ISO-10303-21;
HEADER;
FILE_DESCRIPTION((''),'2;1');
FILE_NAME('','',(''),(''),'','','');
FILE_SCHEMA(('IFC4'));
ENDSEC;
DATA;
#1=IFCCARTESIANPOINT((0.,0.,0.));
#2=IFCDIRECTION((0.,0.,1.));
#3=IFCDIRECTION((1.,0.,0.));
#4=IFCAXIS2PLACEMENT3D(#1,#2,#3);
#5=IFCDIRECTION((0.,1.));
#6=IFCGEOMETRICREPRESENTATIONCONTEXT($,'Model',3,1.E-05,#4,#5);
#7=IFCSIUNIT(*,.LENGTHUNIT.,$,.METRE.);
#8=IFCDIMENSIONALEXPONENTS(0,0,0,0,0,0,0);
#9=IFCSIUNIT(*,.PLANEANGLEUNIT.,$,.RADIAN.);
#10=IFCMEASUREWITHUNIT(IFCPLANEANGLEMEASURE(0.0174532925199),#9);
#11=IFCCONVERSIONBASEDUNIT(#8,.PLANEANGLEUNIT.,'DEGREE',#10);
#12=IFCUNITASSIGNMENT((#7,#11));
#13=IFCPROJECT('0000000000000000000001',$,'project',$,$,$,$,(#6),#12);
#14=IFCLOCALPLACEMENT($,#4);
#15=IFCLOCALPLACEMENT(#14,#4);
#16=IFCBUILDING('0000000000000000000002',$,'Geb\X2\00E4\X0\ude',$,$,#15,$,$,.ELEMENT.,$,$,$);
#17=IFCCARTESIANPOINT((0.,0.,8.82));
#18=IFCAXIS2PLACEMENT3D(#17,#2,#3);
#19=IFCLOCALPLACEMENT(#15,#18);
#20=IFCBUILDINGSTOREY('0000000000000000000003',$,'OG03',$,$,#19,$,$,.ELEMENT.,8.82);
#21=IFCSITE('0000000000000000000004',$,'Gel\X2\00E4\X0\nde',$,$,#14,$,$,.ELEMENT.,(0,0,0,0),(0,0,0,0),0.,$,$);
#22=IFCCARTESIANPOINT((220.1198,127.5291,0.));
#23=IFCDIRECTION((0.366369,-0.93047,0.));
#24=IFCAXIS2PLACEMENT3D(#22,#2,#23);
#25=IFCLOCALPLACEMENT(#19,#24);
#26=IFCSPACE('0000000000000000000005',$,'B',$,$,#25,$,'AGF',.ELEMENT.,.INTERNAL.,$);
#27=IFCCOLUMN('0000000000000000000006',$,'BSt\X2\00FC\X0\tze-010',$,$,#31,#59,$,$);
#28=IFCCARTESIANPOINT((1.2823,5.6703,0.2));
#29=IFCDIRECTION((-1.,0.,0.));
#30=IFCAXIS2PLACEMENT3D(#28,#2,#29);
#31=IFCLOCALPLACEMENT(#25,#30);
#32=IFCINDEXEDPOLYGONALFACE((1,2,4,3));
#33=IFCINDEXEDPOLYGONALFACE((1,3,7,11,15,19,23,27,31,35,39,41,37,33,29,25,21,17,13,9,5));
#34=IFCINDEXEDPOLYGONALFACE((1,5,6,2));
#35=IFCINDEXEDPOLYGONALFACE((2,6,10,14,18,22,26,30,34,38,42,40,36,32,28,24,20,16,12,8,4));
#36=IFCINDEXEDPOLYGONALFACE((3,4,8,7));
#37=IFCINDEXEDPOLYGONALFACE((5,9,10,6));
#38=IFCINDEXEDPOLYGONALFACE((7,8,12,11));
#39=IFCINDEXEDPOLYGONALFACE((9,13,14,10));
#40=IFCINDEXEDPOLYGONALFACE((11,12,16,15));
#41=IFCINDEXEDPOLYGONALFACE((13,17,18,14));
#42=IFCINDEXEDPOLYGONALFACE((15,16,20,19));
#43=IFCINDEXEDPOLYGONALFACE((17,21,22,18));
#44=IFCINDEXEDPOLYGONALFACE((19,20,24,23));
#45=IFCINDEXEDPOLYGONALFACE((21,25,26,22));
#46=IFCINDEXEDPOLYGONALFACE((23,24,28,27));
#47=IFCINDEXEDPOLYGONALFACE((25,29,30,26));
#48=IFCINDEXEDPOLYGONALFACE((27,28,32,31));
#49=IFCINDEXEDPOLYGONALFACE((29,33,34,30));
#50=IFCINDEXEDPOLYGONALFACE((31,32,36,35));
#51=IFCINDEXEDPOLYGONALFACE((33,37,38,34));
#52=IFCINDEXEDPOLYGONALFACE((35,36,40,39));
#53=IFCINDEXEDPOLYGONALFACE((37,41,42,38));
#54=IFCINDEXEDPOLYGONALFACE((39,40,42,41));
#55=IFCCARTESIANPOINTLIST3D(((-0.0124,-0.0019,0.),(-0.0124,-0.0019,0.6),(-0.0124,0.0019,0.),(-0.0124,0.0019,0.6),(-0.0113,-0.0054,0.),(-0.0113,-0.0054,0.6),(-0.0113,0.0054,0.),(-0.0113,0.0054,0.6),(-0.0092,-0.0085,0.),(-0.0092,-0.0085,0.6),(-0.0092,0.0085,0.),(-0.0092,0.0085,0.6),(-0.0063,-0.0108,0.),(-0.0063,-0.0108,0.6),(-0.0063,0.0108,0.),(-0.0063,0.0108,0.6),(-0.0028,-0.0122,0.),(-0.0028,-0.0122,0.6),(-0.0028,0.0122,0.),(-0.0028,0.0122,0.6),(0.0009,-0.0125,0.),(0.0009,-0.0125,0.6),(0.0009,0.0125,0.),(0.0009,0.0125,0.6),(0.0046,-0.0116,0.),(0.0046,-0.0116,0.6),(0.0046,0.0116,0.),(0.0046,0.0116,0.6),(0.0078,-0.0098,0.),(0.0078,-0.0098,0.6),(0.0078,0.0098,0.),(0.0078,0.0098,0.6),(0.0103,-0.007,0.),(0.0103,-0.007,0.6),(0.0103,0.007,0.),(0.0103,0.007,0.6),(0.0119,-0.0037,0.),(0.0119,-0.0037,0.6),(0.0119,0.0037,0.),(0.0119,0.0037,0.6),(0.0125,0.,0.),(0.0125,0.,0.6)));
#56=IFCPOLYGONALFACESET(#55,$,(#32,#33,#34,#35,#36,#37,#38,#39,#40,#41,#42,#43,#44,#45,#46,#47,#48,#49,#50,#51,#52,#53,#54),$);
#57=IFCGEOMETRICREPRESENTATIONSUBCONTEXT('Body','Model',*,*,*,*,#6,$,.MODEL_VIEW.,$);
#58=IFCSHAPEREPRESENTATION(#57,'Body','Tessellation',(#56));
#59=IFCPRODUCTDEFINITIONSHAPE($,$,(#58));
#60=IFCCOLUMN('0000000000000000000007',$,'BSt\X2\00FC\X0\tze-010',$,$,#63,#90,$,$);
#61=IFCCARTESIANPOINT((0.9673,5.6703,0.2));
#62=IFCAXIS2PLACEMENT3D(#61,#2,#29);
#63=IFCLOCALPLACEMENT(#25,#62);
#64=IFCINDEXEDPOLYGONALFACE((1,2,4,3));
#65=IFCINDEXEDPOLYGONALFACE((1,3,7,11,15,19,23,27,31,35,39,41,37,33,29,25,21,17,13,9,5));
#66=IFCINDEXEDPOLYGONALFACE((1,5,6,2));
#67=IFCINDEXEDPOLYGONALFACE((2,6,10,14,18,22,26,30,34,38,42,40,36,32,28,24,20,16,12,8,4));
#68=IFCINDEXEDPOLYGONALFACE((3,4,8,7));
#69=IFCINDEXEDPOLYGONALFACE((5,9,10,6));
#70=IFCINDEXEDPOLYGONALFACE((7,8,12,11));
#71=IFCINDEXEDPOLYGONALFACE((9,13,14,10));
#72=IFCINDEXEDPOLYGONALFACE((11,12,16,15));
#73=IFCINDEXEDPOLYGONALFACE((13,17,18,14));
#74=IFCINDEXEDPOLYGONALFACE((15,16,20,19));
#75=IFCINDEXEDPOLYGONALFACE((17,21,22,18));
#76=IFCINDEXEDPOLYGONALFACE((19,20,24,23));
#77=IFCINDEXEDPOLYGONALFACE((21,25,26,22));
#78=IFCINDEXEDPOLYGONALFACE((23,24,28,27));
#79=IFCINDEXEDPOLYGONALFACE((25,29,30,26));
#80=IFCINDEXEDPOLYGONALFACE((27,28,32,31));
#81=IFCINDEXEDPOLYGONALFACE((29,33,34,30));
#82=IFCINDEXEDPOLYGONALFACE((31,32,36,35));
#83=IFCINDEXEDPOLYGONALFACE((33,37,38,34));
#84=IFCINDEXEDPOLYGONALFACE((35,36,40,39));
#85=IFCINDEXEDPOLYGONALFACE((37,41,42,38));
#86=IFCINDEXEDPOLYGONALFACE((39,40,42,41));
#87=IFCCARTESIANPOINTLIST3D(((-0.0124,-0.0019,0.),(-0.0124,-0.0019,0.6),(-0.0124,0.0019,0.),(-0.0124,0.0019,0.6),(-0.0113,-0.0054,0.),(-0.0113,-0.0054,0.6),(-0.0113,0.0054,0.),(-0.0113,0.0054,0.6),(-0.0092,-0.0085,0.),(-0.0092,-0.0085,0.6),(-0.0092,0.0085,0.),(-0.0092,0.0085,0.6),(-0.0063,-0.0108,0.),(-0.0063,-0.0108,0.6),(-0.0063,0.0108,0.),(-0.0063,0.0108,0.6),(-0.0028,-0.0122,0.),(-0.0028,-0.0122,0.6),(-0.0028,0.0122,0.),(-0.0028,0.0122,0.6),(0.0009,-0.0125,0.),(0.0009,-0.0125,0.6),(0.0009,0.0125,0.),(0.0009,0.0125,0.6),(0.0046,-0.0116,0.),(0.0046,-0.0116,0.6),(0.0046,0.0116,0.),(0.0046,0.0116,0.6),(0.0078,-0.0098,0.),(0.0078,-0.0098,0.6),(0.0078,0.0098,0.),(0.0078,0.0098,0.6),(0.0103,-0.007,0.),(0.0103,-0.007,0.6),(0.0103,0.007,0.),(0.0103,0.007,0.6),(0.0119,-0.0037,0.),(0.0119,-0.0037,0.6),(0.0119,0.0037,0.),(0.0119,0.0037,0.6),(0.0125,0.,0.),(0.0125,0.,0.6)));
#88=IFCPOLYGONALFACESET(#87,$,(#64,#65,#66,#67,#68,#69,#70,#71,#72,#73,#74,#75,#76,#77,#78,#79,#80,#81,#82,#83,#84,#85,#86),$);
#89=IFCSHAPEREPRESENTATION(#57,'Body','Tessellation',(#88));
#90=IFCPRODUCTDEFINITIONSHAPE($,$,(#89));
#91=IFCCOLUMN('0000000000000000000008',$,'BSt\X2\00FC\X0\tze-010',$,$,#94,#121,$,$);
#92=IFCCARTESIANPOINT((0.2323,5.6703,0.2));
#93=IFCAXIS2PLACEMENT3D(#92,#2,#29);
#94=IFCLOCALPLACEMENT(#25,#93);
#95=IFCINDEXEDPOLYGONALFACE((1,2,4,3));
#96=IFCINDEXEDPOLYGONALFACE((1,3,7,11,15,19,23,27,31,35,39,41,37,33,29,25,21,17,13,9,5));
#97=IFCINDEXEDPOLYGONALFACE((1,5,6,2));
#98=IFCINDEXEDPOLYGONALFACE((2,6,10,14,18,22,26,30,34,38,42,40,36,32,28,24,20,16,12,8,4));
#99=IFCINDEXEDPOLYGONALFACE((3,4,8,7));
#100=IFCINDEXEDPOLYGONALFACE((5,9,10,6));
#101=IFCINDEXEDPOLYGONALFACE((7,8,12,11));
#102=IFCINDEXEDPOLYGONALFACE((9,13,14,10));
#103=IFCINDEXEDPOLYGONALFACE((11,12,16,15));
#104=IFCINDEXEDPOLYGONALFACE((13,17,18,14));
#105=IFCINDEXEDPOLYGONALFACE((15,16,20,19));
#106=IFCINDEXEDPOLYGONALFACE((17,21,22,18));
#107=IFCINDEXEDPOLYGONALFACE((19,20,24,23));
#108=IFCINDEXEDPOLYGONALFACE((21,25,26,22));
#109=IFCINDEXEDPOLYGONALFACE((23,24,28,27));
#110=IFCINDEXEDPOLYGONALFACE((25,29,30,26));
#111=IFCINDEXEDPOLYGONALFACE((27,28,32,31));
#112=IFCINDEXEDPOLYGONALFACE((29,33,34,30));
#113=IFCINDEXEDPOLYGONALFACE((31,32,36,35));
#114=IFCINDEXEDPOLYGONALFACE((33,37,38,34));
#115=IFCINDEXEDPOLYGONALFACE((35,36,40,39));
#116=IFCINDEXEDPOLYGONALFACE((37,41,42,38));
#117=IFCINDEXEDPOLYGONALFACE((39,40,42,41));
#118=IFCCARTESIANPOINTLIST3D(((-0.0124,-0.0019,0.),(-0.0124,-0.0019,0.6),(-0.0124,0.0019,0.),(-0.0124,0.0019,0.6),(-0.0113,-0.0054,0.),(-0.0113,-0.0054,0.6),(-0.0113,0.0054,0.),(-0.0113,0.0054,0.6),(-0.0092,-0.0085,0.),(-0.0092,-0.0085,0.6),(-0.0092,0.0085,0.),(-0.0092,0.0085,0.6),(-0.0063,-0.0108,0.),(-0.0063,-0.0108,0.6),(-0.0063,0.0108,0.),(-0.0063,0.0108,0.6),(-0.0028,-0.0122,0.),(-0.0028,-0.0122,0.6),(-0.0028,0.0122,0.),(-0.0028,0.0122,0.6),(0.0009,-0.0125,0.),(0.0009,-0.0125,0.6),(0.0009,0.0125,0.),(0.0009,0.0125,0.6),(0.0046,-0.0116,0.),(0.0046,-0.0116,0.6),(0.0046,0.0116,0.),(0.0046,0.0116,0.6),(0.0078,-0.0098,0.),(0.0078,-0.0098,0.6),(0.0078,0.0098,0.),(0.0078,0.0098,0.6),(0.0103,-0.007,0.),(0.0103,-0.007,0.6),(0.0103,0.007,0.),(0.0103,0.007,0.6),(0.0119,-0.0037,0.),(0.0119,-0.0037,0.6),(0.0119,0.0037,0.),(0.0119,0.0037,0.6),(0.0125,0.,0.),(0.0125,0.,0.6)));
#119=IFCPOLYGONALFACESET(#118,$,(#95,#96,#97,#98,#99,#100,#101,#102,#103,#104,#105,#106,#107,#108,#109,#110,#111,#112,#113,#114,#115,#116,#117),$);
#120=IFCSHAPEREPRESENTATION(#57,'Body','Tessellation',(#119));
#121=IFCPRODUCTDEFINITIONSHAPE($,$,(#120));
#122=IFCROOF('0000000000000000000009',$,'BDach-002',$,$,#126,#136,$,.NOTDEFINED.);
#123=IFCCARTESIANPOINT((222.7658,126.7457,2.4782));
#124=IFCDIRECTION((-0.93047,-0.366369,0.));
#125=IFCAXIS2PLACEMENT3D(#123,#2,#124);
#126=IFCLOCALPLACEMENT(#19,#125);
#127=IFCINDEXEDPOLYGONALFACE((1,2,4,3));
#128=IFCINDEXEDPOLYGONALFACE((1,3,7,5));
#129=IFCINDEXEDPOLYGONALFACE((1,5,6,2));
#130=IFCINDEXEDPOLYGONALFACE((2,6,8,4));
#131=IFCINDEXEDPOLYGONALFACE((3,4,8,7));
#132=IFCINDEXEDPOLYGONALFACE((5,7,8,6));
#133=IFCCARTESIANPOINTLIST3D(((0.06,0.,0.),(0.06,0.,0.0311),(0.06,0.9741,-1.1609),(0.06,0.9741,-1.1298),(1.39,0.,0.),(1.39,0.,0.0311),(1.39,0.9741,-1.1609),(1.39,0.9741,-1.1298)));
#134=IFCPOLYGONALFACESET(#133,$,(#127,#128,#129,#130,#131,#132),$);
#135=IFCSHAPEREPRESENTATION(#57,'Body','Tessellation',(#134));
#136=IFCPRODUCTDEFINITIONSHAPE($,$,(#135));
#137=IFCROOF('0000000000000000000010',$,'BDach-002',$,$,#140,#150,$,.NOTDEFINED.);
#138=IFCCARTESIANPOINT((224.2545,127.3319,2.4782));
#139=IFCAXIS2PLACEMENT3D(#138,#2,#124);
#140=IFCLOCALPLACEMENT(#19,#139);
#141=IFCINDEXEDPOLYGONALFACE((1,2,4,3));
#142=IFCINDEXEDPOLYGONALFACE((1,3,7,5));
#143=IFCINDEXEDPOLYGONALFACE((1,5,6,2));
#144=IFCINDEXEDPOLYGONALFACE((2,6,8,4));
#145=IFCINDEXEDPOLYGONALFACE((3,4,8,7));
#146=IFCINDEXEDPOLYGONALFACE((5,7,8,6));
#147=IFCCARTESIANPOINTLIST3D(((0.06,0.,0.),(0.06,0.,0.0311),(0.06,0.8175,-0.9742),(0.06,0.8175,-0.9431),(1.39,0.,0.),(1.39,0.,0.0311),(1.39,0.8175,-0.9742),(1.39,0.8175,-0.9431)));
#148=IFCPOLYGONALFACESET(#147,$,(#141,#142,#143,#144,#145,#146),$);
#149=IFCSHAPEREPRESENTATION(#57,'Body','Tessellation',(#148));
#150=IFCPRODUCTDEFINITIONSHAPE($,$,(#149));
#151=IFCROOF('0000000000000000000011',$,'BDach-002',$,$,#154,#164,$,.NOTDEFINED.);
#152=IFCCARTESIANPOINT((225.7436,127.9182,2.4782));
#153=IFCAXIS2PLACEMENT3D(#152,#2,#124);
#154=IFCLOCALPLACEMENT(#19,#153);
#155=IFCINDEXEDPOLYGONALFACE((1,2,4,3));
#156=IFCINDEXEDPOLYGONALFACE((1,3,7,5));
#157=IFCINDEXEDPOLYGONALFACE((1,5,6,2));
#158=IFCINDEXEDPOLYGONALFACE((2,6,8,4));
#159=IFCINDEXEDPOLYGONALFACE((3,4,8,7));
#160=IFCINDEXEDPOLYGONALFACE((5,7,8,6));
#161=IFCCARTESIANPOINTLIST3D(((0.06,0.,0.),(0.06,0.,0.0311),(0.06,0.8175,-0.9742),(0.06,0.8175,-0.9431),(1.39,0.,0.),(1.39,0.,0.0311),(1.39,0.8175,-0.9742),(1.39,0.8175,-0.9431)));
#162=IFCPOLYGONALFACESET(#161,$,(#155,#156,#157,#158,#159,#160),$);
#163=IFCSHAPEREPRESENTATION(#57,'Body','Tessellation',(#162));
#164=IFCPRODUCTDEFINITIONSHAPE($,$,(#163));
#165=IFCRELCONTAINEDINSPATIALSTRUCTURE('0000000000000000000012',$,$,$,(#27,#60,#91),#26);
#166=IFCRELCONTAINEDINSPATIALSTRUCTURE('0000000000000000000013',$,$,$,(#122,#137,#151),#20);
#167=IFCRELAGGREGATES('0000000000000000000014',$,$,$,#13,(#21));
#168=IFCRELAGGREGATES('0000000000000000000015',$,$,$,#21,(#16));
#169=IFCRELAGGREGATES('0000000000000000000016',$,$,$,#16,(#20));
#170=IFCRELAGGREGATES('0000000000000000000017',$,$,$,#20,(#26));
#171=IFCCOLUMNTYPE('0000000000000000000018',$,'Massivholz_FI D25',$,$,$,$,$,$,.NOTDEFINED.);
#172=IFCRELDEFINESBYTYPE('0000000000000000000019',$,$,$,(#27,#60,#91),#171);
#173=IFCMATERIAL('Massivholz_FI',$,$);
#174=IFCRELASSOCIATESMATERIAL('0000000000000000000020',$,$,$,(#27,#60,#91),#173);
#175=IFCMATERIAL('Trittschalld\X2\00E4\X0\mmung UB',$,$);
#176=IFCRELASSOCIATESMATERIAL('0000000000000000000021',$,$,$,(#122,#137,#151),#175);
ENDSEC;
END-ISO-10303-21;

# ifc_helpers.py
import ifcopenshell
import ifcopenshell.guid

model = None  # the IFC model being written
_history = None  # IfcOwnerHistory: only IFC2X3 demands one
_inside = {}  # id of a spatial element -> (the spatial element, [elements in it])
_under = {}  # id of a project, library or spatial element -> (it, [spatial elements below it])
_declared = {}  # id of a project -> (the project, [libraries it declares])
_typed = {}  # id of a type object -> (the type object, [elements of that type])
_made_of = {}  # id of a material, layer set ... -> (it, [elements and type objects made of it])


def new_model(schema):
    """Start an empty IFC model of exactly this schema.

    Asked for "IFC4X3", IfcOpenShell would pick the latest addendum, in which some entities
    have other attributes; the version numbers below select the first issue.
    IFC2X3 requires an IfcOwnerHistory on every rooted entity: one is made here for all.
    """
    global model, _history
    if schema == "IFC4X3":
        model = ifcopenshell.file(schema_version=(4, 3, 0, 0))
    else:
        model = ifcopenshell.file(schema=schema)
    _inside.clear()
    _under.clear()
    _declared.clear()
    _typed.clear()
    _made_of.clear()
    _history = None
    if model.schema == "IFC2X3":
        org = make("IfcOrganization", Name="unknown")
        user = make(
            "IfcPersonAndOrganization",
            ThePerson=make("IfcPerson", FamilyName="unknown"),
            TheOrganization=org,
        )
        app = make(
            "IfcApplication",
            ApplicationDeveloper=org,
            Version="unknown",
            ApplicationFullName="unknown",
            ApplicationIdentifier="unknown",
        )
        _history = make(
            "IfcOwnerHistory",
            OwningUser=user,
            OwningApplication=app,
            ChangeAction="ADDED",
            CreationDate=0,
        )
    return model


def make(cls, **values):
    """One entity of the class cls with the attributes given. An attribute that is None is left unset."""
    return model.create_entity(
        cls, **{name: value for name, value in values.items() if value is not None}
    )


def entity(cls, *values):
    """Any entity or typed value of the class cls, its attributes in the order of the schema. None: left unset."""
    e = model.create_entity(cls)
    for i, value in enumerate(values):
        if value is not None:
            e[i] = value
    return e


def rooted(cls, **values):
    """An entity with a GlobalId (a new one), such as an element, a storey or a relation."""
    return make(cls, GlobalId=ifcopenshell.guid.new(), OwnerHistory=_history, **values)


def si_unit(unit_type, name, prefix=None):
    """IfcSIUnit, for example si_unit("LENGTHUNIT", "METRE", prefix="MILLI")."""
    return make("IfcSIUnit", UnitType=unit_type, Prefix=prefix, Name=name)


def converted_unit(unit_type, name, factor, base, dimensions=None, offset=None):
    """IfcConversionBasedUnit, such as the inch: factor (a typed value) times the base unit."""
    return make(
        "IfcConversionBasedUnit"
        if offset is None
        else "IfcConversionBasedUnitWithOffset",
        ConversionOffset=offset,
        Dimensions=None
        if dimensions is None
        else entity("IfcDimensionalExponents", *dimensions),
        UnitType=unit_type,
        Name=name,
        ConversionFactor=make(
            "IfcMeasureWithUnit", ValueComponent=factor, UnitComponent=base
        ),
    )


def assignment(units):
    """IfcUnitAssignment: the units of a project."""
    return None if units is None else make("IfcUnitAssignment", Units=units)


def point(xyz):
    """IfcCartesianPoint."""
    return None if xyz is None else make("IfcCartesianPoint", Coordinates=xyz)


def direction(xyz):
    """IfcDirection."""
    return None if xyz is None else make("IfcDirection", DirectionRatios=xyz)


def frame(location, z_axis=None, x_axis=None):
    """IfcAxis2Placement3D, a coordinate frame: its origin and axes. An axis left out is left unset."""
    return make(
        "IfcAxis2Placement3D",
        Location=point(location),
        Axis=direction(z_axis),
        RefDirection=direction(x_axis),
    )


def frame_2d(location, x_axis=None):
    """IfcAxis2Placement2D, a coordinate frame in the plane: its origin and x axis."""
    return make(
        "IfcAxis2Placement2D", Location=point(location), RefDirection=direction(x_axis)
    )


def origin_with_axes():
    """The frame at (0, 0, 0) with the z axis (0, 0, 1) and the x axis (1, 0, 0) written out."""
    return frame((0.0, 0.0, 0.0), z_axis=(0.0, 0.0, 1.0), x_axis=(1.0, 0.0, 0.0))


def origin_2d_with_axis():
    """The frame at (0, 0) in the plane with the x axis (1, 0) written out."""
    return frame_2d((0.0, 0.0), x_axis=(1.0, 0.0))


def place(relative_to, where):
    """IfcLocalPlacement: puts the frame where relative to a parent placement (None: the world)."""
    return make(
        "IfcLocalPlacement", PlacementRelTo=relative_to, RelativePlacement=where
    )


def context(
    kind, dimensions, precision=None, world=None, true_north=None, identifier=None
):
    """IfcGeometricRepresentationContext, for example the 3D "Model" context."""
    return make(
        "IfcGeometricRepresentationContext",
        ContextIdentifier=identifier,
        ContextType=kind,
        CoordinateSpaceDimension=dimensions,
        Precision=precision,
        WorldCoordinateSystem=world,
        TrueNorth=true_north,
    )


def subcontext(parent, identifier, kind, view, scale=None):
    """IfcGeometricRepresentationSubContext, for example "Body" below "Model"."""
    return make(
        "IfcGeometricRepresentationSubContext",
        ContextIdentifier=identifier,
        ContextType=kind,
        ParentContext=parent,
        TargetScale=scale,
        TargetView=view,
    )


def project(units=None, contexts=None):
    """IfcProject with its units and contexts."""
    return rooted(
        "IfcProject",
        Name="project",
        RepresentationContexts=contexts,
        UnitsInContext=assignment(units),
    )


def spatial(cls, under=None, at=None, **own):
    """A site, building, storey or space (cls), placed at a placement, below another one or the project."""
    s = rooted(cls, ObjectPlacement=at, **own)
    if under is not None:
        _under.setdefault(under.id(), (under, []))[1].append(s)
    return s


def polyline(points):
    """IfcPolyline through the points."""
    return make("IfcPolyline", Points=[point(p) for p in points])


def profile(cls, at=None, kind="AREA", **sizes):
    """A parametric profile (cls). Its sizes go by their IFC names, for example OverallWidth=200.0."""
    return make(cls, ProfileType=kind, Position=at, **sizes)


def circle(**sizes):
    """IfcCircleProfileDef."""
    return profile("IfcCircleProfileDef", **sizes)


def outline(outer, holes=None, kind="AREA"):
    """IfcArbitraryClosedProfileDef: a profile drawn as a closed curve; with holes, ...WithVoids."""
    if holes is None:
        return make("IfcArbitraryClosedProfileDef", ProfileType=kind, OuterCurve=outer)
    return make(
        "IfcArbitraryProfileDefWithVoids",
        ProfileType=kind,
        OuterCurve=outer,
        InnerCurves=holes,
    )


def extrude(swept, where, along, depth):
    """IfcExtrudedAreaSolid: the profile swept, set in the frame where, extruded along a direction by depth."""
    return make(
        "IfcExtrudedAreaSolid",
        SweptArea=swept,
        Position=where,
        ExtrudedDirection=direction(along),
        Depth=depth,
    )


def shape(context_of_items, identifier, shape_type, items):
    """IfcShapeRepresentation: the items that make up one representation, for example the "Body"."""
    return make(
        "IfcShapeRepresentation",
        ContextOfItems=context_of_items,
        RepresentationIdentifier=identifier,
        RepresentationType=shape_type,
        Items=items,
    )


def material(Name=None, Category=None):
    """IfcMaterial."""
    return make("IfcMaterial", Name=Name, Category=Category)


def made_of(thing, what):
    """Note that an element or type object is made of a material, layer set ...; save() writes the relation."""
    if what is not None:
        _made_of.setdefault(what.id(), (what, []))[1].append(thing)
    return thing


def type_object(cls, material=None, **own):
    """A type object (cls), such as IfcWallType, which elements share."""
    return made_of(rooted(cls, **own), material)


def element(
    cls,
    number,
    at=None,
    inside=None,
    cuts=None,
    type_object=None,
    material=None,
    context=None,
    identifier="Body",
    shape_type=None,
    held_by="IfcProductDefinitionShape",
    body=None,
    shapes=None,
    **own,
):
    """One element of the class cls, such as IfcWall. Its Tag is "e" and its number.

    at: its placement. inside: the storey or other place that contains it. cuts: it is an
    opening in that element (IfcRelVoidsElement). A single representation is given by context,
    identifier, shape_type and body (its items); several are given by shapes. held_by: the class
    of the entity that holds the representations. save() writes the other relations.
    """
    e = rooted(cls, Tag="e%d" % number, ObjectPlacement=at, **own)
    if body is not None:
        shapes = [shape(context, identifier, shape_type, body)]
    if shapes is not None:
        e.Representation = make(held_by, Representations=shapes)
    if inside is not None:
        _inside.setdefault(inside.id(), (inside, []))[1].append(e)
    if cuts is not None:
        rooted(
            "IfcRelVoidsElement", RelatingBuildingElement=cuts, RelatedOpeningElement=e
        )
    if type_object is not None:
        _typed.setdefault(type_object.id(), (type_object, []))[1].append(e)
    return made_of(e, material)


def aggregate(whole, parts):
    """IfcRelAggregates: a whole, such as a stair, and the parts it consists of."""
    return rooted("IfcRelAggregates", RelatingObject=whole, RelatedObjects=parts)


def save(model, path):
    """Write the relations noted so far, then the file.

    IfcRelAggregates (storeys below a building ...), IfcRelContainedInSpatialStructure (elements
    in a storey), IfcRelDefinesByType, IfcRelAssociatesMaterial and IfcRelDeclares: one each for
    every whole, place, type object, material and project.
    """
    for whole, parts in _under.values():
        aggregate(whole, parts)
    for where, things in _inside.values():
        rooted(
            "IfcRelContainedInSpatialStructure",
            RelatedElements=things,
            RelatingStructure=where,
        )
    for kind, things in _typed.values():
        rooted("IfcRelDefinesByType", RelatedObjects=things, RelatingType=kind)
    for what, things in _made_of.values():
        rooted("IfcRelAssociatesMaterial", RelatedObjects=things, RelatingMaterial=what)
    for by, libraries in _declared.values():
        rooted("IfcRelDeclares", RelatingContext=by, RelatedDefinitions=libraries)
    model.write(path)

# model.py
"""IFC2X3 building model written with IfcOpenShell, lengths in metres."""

from ifc_helpers import new_model, entity, si_unit, converted_unit, direction, frame, origin_with_axes, origin_2d_with_axis, place, context, subcontext, project, spatial, polyline, circle, outline, extrude, material, type_object, element, save


model = new_model("IFC2X3")

# Units and contexts
model_context = context("Model", 3, precision=1e-05, world=origin_with_axes(), true_north=direction((0.0, 1.0)))
body_context = subcontext(model_context, "Body", "Model", "MODEL_VIEW")
ifc_project = project(units=[si_unit("LENGTHUNIT", "METRE"), converted_unit("PLANEANGLEUNIT", "DEGREE", entity("IfcPlaneAngleMeasure", 0.0174532925199), si_unit("PLANEANGLEUNIT", "RADIAN"), dimensions=[0, 0, 0, 0, 0, 0, 0])], contexts=[model_context])

# Site, building, storey, space
site_placement = place(None, origin_with_axes())
site = spatial("IfcSite", under=ifc_project, at=site_placement, Name="Gelände", CompositionType="ELEMENT", RefLatitude=(0, 0, 0, 0), RefLongitude=(0, 0, 0, 0), RefElevation=0.0)
building_placement = place(site_placement, origin_with_axes())
building = spatial("IfcBuilding", under=site, at=building_placement, Name="Gebäude", CompositionType="ELEMENT")
storey_placement = place(building_placement, frame((0.0, 0.0, 8.82), z_axis=(0.0, 0.0, 1.0), x_axis=(1.0, 0.0, 0.0)))
storey = spatial("IfcBuildingStorey", under=building, at=storey_placement, Name="OG03", CompositionType="ELEMENT", Elevation=8.82)
space_1_placement = place(storey_placement, frame((220.1198, 127.5291, 0.0), z_axis=(0.0, 0.0, 1.0), x_axis=(0.366369, -0.93047, 0.0)))
space_1 = spatial("IfcSpace", under=storey, at=space_1_placement, Name="B", LongName="AGF", CompositionType="ELEMENT", InteriorOrExteriorSpace="INTERNAL")

# Columns
ifc_material_1 = material(Name="Massivholz_FI")
column_type_1 = type_object("IfcColumnType", Name="Massivholz_FI D25", PredefinedType="NOTDEFINED")
for number, where, z_axis, x_axis, name in (
    (1, (1.2823, 5.6703, 0.2), (0.0, 0.0, 1.0), (-1.0, 0.0, 0.0), "BStütze-010"),
    (2, (0.9673, 5.6703, 0.2), (0.0, 0.0, 1.0), (-1.0, 0.0, 0.0), "BStütze-010"),
    (3, (0.2323, 5.6703, 0.2), (0.0, 0.0, 1.0), (-1.0, 0.0, 0.0), "BStütze-010"),
):
    element("IfcColumn", number, at=place(space_1_placement, frame(where, z_axis=z_axis, x_axis=x_axis)), inside=space_1, type_object=column_type_1, material=ifc_material_1, Name=name, context=body_context, shape_type="SweptSolid", body=[
        extrude(circle(Radius=0.0125, at=origin_2d_with_axis()), origin_with_axes(), (0.0, 0.0, 1.0), 0.6),
    ])

# Roofs
ifc_material_2 = material(Name="Trittschalldämmung UB")
roof_1_placement = place(storey_placement, frame((222.7658, 126.7457, 2.4782), z_axis=(0.0, 0.0, 1.0), x_axis=(-0.93047, -0.366369, 0.0)))
element("IfcRoof", 4, at=roof_1_placement, inside=storey, material=ifc_material_2, Name="BDach-002", ShapeType="NOTDEFINED", context=body_context, shape_type="SweptSolid", body=[
    extrude(outline(polyline([(1.39, 0.0), (1.39, 1.5154), (0.06, 1.5154), (0.06, 0.0), (1.39, 0.0)])), frame((0.0, 0.0, 0.0), z_axis=(0.0, 0.766044, 0.642788), x_axis=(1.0, 0.0, 0.0)), (0.0, -0.766044, 0.642788), 0.0311),
])
roof_2_placement = place(storey_placement, frame((224.2545, 127.3319, 2.4782), z_axis=(0.0, 0.0, 1.0), x_axis=(-0.93047, -0.366369, 0.0)))
element("IfcRoof", 5, at=roof_2_placement, inside=storey, material=ifc_material_2, Name="BDach-002", ShapeType="NOTDEFINED", context=body_context, shape_type="SweptSolid", body=[
    extrude(outline(polyline([(1.39, 0.0), (1.39, 1.2717), (0.06, 1.2717), (0.06, 0.0), (1.39, 0.0)])), frame((0.0, 0.0, 0.0), z_axis=(0.0, 0.766044, 0.642788), x_axis=(1.0, 0.0, 0.0)), (0.0, -0.766044, 0.642788), 0.0311),
])
roof_3_placement = place(storey_placement, frame((225.7436, 127.9182, 2.4782), z_axis=(0.0, 0.0, 1.0), x_axis=(-0.93047, -0.366369, 0.0)))
element("IfcRoof", 6, at=roof_3_placement, inside=storey, material=ifc_material_2, Name="BDach-002", ShapeType="NOTDEFINED", context=body_context, shape_type="SweptSolid", body=[
    extrude(outline(polyline([(1.39, 0.0), (1.39, 1.2717), (0.06, 1.2717), (0.06, 0.0), (1.39, 0.0)])), frame((0.0, 0.0, 0.0), z_axis=(0.0, 0.766044, 0.642788), x_axis=(1.0, 0.0, 0.0)), (0.0, -0.766044, 0.642788), 0.0311),
])

save(model, "model.ifc")
